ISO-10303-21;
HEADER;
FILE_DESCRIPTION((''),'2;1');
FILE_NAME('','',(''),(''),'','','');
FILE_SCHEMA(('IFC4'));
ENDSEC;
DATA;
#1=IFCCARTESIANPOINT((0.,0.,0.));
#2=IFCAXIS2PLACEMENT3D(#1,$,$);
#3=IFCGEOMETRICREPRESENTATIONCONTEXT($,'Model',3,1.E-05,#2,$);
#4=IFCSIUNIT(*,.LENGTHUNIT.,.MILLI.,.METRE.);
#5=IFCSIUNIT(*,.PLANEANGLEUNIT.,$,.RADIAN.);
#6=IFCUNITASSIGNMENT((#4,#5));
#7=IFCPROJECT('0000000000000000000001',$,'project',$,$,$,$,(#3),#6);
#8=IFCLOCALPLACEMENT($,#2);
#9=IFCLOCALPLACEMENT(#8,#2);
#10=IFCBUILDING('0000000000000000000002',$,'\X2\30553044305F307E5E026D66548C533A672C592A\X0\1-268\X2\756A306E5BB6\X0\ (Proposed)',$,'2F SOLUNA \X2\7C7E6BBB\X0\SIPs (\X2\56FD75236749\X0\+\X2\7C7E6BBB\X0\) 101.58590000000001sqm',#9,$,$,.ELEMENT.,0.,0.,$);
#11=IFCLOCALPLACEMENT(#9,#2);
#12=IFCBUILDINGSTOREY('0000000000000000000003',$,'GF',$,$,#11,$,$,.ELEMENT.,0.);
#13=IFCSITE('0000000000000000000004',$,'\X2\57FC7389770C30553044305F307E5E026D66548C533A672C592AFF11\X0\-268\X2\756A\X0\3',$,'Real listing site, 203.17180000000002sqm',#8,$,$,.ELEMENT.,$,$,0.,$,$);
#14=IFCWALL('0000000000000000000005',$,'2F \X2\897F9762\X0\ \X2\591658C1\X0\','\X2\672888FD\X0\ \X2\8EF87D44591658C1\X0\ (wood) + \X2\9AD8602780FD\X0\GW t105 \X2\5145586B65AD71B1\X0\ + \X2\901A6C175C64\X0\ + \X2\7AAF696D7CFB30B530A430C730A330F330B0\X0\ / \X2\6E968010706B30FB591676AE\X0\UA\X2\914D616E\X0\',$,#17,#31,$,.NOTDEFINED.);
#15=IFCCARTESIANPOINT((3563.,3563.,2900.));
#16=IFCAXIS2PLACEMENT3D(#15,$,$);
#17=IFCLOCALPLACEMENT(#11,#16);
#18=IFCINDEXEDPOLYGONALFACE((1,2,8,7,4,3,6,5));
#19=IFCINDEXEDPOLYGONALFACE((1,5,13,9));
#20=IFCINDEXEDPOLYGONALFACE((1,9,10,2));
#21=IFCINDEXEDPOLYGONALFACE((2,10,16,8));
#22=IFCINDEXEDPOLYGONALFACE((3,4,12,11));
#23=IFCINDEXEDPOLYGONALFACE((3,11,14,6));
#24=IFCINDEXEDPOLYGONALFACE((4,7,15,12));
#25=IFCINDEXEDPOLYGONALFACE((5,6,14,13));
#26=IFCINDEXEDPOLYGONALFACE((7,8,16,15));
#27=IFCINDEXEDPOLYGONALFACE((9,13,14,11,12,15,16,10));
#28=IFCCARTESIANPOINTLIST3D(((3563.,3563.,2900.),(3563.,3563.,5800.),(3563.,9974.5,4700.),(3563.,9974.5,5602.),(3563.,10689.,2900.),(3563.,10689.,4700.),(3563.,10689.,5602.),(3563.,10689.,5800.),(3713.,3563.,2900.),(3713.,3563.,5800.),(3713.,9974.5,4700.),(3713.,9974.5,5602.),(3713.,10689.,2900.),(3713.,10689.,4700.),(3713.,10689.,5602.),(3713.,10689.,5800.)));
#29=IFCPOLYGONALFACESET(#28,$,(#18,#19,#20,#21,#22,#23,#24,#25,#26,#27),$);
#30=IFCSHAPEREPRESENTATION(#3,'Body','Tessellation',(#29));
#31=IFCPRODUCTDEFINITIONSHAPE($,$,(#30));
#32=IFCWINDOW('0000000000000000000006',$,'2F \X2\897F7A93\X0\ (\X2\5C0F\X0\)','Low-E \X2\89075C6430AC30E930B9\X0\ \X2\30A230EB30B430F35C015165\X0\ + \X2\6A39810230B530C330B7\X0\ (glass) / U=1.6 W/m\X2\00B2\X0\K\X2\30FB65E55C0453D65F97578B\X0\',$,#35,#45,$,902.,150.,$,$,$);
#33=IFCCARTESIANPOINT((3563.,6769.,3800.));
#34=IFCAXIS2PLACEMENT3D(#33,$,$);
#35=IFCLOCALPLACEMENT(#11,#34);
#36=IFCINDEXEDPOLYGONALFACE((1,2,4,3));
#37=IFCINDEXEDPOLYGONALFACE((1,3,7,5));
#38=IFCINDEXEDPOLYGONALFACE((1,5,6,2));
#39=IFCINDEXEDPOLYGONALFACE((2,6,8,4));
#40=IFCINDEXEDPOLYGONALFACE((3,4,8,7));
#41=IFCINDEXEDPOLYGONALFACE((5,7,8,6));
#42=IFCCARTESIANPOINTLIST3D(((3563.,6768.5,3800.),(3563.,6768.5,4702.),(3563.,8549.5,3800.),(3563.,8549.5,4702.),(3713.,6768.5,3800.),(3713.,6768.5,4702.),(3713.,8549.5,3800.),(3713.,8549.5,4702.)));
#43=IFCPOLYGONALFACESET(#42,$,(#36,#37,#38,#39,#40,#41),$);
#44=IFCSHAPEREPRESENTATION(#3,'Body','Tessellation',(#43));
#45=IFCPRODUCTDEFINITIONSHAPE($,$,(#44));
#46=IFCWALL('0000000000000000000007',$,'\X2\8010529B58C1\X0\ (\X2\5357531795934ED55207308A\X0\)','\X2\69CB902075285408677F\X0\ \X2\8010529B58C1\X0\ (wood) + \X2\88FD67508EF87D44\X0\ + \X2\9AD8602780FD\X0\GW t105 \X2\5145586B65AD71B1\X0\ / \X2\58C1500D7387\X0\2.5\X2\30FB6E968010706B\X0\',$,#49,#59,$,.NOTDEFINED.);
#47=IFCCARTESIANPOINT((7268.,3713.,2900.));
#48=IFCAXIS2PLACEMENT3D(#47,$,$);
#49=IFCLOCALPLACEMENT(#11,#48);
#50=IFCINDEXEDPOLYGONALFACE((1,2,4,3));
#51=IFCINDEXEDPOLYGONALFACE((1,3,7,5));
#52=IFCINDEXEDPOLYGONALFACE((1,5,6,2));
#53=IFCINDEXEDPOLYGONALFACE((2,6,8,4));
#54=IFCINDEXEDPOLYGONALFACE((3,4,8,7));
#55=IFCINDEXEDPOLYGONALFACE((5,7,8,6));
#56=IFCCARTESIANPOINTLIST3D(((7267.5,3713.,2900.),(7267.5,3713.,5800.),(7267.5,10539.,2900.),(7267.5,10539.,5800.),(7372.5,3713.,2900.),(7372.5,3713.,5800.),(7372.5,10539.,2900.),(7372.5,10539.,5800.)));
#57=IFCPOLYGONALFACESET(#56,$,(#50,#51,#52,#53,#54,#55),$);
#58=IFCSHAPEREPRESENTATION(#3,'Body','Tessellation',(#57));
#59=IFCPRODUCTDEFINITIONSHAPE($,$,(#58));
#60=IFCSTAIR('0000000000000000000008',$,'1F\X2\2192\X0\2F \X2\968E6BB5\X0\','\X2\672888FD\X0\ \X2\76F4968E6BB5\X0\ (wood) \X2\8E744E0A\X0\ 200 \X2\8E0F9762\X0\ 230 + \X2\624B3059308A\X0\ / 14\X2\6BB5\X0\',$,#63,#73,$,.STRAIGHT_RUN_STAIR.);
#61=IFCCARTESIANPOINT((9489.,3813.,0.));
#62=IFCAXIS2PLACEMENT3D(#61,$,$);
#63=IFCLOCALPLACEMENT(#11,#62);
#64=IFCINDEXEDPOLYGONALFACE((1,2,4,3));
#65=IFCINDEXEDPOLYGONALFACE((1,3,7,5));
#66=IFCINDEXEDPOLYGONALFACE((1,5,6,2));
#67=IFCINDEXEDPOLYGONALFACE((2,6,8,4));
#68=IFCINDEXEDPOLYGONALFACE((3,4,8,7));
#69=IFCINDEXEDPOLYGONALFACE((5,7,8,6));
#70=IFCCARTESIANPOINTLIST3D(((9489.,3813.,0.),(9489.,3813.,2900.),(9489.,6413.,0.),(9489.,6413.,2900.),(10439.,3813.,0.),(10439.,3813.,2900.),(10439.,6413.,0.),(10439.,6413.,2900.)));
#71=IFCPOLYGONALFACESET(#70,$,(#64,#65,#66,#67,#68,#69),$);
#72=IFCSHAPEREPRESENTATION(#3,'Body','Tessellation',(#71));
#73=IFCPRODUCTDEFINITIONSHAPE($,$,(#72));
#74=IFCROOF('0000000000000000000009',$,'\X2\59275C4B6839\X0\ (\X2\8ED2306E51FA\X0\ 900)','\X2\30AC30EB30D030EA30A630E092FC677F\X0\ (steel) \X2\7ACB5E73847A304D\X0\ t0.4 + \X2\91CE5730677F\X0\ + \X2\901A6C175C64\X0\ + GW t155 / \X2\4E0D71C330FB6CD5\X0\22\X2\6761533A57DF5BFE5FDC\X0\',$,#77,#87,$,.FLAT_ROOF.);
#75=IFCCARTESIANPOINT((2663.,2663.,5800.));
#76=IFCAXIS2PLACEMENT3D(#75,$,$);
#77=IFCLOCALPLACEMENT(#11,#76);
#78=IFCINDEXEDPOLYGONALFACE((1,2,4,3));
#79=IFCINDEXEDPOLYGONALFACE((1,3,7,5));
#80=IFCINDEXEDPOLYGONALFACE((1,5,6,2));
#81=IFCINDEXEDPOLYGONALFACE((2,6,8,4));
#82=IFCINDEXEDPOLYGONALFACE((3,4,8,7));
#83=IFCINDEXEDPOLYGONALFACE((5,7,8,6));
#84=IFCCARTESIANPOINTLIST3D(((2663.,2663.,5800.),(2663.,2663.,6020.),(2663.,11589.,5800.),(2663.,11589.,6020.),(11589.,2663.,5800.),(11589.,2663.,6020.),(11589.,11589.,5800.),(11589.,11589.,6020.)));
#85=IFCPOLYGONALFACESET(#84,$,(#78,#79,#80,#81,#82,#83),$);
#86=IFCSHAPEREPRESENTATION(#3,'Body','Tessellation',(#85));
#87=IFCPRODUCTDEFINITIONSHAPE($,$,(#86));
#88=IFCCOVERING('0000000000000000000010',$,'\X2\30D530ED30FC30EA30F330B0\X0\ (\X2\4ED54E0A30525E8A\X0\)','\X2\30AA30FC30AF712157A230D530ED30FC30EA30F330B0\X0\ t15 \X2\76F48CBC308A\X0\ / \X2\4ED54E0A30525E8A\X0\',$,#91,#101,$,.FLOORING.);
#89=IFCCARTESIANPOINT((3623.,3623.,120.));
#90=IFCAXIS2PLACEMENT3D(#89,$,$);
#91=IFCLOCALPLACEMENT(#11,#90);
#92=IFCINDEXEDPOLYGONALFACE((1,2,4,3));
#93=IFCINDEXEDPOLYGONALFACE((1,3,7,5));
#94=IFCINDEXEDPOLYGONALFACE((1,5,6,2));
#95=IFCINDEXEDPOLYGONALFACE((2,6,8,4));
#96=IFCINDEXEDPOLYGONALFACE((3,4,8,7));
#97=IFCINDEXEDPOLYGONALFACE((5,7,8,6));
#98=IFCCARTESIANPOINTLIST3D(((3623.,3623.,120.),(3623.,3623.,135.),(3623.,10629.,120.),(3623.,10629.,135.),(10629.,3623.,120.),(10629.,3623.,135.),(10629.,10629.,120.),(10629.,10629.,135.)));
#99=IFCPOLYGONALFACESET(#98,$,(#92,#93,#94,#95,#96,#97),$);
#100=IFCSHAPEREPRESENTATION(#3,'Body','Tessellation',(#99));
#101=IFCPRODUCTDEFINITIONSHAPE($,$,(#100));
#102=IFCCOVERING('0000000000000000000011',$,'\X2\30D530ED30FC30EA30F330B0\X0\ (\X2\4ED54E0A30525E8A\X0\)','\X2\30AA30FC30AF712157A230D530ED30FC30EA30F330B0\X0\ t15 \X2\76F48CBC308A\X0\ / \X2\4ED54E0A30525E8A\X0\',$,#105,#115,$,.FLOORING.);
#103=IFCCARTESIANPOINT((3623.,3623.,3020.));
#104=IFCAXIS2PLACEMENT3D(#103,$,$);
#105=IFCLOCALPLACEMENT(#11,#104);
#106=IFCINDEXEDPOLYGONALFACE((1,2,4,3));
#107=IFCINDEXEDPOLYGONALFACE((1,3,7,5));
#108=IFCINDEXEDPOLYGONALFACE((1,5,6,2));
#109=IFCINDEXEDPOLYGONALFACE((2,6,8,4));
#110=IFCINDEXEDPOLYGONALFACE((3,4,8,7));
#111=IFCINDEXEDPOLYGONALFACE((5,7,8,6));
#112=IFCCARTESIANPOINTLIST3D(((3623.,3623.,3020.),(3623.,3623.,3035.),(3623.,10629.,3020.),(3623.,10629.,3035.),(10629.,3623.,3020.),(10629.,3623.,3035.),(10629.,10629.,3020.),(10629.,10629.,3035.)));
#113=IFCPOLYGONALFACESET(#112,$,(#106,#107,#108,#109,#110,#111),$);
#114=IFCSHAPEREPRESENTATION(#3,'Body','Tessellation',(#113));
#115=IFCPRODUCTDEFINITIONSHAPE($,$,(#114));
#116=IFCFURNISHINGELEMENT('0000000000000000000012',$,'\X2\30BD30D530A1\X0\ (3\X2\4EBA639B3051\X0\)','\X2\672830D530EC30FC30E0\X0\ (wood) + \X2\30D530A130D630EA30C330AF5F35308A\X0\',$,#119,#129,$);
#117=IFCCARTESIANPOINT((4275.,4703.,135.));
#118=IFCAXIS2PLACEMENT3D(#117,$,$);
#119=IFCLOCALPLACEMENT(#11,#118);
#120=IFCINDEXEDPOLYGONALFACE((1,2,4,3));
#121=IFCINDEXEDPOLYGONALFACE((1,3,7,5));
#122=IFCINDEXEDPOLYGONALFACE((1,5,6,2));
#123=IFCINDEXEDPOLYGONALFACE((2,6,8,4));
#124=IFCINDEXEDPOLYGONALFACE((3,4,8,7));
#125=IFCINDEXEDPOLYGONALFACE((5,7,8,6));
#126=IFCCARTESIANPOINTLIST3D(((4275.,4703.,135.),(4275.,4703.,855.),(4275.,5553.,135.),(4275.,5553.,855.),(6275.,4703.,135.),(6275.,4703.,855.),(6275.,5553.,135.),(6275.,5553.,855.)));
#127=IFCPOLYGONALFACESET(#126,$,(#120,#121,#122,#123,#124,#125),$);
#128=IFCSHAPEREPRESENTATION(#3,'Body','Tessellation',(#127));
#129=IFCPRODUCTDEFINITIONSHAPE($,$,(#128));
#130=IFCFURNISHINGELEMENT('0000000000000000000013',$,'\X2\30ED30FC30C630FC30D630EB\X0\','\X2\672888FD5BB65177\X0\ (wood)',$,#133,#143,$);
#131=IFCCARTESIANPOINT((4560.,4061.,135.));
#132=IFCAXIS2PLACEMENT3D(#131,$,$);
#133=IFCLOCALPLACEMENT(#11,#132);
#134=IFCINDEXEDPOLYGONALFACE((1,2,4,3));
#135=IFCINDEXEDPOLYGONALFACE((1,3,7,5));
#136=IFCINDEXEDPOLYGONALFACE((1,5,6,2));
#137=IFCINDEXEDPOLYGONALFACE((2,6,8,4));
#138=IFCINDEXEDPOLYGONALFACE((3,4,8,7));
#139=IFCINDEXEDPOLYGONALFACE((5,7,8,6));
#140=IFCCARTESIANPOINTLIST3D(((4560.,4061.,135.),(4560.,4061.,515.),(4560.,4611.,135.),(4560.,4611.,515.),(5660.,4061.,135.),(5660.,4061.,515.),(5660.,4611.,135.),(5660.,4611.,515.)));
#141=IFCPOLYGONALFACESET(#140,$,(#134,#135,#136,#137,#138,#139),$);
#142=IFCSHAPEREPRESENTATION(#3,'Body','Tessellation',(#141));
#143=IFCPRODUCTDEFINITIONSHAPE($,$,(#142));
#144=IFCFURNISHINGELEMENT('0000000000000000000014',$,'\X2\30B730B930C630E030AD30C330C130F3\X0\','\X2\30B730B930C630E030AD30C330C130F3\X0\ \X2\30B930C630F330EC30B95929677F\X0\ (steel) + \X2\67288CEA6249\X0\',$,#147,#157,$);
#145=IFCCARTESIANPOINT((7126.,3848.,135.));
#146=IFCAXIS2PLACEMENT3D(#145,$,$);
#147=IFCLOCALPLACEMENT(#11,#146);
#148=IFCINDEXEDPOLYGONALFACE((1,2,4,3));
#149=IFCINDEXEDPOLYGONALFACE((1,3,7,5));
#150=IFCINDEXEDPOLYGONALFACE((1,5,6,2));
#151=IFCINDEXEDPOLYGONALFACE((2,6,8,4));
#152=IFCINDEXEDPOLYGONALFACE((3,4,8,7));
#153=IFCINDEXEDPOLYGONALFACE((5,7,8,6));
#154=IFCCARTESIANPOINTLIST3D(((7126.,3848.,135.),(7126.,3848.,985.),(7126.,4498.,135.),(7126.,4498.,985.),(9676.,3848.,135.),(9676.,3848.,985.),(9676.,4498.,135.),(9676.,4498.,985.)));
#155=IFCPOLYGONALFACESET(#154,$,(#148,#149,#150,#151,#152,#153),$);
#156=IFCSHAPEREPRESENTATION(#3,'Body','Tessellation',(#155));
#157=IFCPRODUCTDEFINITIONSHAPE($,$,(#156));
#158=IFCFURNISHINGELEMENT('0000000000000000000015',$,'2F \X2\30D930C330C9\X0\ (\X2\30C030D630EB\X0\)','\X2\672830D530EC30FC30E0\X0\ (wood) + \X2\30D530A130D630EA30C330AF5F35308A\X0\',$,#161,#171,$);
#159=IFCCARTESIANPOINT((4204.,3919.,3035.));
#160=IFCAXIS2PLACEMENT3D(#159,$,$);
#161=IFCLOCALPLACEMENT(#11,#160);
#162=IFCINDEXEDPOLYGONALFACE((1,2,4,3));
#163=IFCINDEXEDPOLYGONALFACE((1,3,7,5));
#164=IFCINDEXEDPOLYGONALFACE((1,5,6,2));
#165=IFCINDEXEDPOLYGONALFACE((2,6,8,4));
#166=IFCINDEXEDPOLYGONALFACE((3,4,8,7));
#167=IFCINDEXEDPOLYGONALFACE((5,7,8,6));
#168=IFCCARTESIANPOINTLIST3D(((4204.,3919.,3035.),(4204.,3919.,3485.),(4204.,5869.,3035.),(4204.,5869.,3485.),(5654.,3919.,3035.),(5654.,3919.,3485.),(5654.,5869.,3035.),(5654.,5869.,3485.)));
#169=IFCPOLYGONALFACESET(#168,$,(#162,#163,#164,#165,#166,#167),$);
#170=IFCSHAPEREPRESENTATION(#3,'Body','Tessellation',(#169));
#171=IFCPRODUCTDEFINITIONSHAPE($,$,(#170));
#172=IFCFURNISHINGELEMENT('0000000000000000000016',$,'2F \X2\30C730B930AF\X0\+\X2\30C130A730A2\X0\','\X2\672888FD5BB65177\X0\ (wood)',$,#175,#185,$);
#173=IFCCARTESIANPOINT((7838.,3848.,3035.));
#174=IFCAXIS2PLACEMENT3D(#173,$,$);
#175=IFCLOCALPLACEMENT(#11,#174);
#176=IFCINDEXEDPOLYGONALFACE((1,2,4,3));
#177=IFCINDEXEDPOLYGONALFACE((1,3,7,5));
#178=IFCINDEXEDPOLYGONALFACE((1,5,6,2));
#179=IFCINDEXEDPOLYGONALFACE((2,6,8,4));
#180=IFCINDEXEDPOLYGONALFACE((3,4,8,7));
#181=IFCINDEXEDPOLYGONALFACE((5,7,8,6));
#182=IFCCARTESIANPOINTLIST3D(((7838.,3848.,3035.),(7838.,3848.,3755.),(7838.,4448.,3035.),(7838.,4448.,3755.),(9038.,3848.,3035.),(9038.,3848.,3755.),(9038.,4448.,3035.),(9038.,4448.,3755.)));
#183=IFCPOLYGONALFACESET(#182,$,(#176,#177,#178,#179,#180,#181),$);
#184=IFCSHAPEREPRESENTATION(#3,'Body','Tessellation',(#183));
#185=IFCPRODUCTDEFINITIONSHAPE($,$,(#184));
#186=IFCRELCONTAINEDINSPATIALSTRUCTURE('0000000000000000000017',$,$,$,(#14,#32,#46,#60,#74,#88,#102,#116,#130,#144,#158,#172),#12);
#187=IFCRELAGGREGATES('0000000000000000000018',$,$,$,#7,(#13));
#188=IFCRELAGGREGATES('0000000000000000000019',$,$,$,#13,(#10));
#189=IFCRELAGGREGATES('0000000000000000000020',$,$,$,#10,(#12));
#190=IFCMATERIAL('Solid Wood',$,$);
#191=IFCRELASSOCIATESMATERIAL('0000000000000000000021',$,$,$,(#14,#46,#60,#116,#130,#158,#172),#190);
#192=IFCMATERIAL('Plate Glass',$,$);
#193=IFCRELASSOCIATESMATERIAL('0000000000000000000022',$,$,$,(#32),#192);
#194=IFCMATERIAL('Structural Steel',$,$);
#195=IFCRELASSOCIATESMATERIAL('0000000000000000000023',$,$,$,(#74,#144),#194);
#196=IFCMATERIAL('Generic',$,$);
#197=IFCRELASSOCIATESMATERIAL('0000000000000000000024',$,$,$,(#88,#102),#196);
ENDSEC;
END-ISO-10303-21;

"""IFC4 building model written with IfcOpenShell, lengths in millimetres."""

from ifc_helpers import new_model, si_unit, frame, frame_2d, origin, place, context, project, spatial, rectangle, extrude, material, element, fill, save


model = new_model("IFC4")

# Units and contexts
model_context = context("Model", 3, precision=1e-05, world=origin())
ifc_project = project(units=[si_unit("LENGTHUNIT", "METRE", prefix="MILLI"), si_unit("PLANEANGLEUNIT", "RADIAN")], contexts=[model_context])

# Site, building, storey
site_placement = place(None, origin())
site = spatial("IfcSite", under=ifc_project, at=site_placement, Name="埼玉県さいたま市浦和区本太１-268番3", ObjectType="Real listing site, 203.17180000000002sqm", CompositionType="ELEMENT", RefElevation=0.0)
building_placement = place(site_placement, origin())
building = spatial("IfcBuilding", under=site, at=building_placement, Name="さいたま市浦和区本太1-268番の家 (Proposed)", ObjectType="2F SOLUNA 籾殻SIPs (国産杉+籾殻) 101.58590000000001sqm", CompositionType="ELEMENT", ElevationOfRefHeight=0.0, ElevationOfTerrain=0.0)
storey_placement = place(building_placement, origin())
storey = spatial("IfcBuildingStorey", under=building, at=storey_placement, Name="GF", CompositionType="ELEMENT", Elevation=0.0)

# Shared definitions
ifc_material_1 = material(Name="Solid Wood")

# Shared definitions
ifc_material_2 = material(Name="Plate Glass")

# Wall, opening, window
wall_1_placement = place(storey_placement, frame((3563.0, 3563.0, 2900.0)))
wall_1 = element("IfcWall", 1, at=wall_1_placement, inside=storey, material=ifc_material_1, Name="2F 西面 外壁", Description="木製 軸組外壁 (wood) + 高性能GW t105 充填断熱 + 通気層 + 窯業系サイディング / 準耐火・外皮UA配慮", PredefinedType="NOTDEFINED", context=model_context, shape_type="SweptSolid", body=[
    extrude(rectangle(XDim=150.0, YDim=7126.0, at=frame_2d((75.0, 3563.0))), frame((3563.0, 3563.0, 2900.0)), (0.0, 0.0, 1.0), 2900.0),
])
opening_1_placement = place(storey_placement, frame((3563.0, 6769.0, 3800.0)))
opening_1 = element("IfcOpeningElement", 2, at=opening_1_placement, cuts=wall_1, PredefinedType="NOTDEFINED", context=model_context, shape_type="SweptSolid", body=[
    extrude(rectangle(XDim=150.0, YDim=1781.0, at=frame_2d((75.0, 890.0))), frame((3563.0, 6769.0, 3800.0)), (0.0, 0.0, 1.0), 902.0),
])
window_1_placement = place(storey_placement, frame((3563.0, 6769.0, 3800.0)))
window_1 = element("IfcWindow", 3, at=window_1_placement, inside=storey, material=ifc_material_2, Name="2F 西窓 (小)", Description="Low-E 複層ガラス アルゴン封入 + 樹脂サッシ (glass) / U=1.6 W/m²K・日射取得型", OverallHeight=902.0, OverallWidth=150.0, context=model_context, shape_type="SweptSolid", body=[
    extrude(rectangle(XDim=150.0, YDim=1781.0, at=frame_2d((75.0, 890.0))), frame((3563.0, 6769.0, 3800.0)), (0.0, 0.0, 1.0), 902.0),
])
fill(opening_1, window_1)

# Wall
wall_2_placement = place(storey_placement, frame((7268.0, 3713.0, 2900.0)))
element("IfcWall", 4, at=wall_2_placement, inside=storey, material=ifc_material_1, Name="耐力壁 (南北間仕切り)", Description="構造用合板 耐力壁 (wood) + 製材軸組 + 高性能GW t105 充填断熱 / 壁倍率2.5・準耐火", PredefinedType="NOTDEFINED", context=model_context, shape_type="SweptSolid", body=[
    extrude(rectangle(XDim=105.0, YDim=6826.0, at=frame_2d((52.0, 3413.0))), frame((7268.0, 3713.0, 2900.0)), (0.0, 0.0, 1.0), 2900.0),
])

# Stair
stair_placement = place(storey_placement, frame((9489.0, 3813.0, 0.0)))
element("IfcStair", 5, at=stair_placement, inside=storey, material=ifc_material_1, Name="1F→2F 階段", Description="木製 直階段 (wood) 蹴上 200 踏面 230 + 手すり / 14段", PredefinedType="STRAIGHT_RUN_STAIR", context=model_context, shape_type="SweptSolid", body=[
    extrude(rectangle(XDim=950.0, YDim=2600.0, at=frame_2d((475.0, 1300.0))), frame((9489.0, 3813.0, 0.0)), (0.0, 0.0, 1.0), 2900.0),
])

# Roof
ifc_material_3 = material(Name="Structural Steel")
roof_placement = place(storey_placement, frame((2663.0, 2663.0, 5800.0)))
element("IfcRoof", 6, at=roof_placement, inside=storey, material=ifc_material_3, Name="大屋根 (軒の出 900)", Description="ガルバリウム鋼板 (steel) 立平葺き t0.4 + 野地板 + 通気層 + GW t155 / 不燃・法22条区域対応", PredefinedType="FLAT_ROOF", context=model_context, shape_type="SweptSolid", body=[
    extrude(rectangle(XDim=8926.0, YDim=8926.0, at=frame_2d((4463.0, 4463.0))), frame((2663.0, 2663.0, 5800.0)), (0.0, 0.0, 1.0), 220.0),
])

# Coverings
ifc_material_4 = material(Name="Generic")
covering_1_placement = place(storey_placement, frame((3623.0, 3623.0, 120.0)))
element("IfcCovering", 7, at=covering_1_placement, inside=storey, material=ifc_material_4, Name="フローリング (仕上げ床)", Description="オーク無垢フローリング t15 直貼り / 仕上げ床", PredefinedType="FLOORING", context=model_context, shape_type="SweptSolid", body=[
    extrude(rectangle(XDim=7006.0, YDim=7006.0, at=frame_2d((3503.0, 3503.0))), frame((3623.0, 3623.0, 120.0)), (0.0, 0.0, 1.0), 15.0),
])
covering_2_placement = place(storey_placement, frame((3623.0, 3623.0, 3020.0)))
element("IfcCovering", 8, at=covering_2_placement, inside=storey, material=ifc_material_4, Name="フローリング (仕上げ床)", Description="オーク無垢フローリング t15 直貼り / 仕上げ床", PredefinedType="FLOORING", context=model_context, shape_type="SweptSolid", body=[
    extrude(rectangle(XDim=7006.0, YDim=7006.0, at=frame_2d((3503.0, 3503.0))), frame((3623.0, 3623.0, 3020.0)), (0.0, 0.0, 1.0), 15.0),
])

# Furnishing elements
furnishing_1_placement = place(storey_placement, frame((4275.0, 4703.0, 135.0)))
element("IfcFurnishingElement", 9, at=furnishing_1_placement, inside=storey, material=ifc_material_1, Name="ソファ (3人掛け)", Description="木フレーム (wood) + ファブリック張り", context=model_context, shape_type="SweptSolid", body=[
    extrude(rectangle(XDim=2000.0, YDim=850.0, at=frame_2d((1000.0, 425.0))), frame((4275.0, 4703.0, 135.0)), (0.0, 0.0, 1.0), 720.0),
])
furnishing_2_placement = place(storey_placement, frame((4560.0, 4061.0, 135.0)))
element("IfcFurnishingElement", 10, at=furnishing_2_placement, inside=storey, material=ifc_material_1, Name="ローテーブル", Description="木製家具 (wood)", context=model_context, shape_type="SweptSolid", body=[
    extrude(rectangle(XDim=1100.0, YDim=550.0, at=frame_2d((550.0, 275.0))), frame((4560.0, 4061.0, 135.0)), (0.0, 0.0, 1.0), 380.0),
])
furnishing_3_placement = place(storey_placement, frame((7126.0, 3848.0, 135.0)))
element("IfcFurnishingElement", 11, at=furnishing_3_placement, inside=storey, material=ifc_material_3, Name="システムキッチン", Description="システムキッチン ステンレス天板 (steel) + 木質扉", context=model_context, shape_type="SweptSolid", body=[
    extrude(rectangle(XDim=2550.0, YDim=650.0, at=frame_2d((1275.0, 325.0))), frame((7126.0, 3848.0, 135.0)), (0.0, 0.0, 1.0), 850.0),
])
furnishing_4_placement = place(storey_placement, frame((4204.0, 3919.0, 3035.0)))
element("IfcFurnishingElement", 12, at=furnishing_4_placement, inside=storey, material=ifc_material_1, Name="2F ベッド (ダブル)", Description="木フレーム (wood) + ファブリック張り", context=model_context, shape_type="SweptSolid", body=[
    extrude(rectangle(XDim=1450.0, YDim=1950.0, at=frame_2d((725.0, 975.0))), frame((4204.0, 3919.0, 3035.0)), (0.0, 0.0, 1.0), 450.0),
])
furnishing_5_placement = place(storey_placement, frame((7838.0, 3848.0, 3035.0)))
element("IfcFurnishingElement", 13, at=furnishing_5_placement, inside=storey, material=ifc_material_1, Name="2F デスク+チェア", Description="木製家具 (wood)", context=model_context, shape_type="SweptSolid", body=[
    extrude(rectangle(XDim=1200.0, YDim=600.0, at=frame_2d((600.0, 300.0))), frame((7838.0, 3848.0, 3035.0)), (0.0, 0.0, 1.0), 720.0),
])

save(model, "model.ifc")
